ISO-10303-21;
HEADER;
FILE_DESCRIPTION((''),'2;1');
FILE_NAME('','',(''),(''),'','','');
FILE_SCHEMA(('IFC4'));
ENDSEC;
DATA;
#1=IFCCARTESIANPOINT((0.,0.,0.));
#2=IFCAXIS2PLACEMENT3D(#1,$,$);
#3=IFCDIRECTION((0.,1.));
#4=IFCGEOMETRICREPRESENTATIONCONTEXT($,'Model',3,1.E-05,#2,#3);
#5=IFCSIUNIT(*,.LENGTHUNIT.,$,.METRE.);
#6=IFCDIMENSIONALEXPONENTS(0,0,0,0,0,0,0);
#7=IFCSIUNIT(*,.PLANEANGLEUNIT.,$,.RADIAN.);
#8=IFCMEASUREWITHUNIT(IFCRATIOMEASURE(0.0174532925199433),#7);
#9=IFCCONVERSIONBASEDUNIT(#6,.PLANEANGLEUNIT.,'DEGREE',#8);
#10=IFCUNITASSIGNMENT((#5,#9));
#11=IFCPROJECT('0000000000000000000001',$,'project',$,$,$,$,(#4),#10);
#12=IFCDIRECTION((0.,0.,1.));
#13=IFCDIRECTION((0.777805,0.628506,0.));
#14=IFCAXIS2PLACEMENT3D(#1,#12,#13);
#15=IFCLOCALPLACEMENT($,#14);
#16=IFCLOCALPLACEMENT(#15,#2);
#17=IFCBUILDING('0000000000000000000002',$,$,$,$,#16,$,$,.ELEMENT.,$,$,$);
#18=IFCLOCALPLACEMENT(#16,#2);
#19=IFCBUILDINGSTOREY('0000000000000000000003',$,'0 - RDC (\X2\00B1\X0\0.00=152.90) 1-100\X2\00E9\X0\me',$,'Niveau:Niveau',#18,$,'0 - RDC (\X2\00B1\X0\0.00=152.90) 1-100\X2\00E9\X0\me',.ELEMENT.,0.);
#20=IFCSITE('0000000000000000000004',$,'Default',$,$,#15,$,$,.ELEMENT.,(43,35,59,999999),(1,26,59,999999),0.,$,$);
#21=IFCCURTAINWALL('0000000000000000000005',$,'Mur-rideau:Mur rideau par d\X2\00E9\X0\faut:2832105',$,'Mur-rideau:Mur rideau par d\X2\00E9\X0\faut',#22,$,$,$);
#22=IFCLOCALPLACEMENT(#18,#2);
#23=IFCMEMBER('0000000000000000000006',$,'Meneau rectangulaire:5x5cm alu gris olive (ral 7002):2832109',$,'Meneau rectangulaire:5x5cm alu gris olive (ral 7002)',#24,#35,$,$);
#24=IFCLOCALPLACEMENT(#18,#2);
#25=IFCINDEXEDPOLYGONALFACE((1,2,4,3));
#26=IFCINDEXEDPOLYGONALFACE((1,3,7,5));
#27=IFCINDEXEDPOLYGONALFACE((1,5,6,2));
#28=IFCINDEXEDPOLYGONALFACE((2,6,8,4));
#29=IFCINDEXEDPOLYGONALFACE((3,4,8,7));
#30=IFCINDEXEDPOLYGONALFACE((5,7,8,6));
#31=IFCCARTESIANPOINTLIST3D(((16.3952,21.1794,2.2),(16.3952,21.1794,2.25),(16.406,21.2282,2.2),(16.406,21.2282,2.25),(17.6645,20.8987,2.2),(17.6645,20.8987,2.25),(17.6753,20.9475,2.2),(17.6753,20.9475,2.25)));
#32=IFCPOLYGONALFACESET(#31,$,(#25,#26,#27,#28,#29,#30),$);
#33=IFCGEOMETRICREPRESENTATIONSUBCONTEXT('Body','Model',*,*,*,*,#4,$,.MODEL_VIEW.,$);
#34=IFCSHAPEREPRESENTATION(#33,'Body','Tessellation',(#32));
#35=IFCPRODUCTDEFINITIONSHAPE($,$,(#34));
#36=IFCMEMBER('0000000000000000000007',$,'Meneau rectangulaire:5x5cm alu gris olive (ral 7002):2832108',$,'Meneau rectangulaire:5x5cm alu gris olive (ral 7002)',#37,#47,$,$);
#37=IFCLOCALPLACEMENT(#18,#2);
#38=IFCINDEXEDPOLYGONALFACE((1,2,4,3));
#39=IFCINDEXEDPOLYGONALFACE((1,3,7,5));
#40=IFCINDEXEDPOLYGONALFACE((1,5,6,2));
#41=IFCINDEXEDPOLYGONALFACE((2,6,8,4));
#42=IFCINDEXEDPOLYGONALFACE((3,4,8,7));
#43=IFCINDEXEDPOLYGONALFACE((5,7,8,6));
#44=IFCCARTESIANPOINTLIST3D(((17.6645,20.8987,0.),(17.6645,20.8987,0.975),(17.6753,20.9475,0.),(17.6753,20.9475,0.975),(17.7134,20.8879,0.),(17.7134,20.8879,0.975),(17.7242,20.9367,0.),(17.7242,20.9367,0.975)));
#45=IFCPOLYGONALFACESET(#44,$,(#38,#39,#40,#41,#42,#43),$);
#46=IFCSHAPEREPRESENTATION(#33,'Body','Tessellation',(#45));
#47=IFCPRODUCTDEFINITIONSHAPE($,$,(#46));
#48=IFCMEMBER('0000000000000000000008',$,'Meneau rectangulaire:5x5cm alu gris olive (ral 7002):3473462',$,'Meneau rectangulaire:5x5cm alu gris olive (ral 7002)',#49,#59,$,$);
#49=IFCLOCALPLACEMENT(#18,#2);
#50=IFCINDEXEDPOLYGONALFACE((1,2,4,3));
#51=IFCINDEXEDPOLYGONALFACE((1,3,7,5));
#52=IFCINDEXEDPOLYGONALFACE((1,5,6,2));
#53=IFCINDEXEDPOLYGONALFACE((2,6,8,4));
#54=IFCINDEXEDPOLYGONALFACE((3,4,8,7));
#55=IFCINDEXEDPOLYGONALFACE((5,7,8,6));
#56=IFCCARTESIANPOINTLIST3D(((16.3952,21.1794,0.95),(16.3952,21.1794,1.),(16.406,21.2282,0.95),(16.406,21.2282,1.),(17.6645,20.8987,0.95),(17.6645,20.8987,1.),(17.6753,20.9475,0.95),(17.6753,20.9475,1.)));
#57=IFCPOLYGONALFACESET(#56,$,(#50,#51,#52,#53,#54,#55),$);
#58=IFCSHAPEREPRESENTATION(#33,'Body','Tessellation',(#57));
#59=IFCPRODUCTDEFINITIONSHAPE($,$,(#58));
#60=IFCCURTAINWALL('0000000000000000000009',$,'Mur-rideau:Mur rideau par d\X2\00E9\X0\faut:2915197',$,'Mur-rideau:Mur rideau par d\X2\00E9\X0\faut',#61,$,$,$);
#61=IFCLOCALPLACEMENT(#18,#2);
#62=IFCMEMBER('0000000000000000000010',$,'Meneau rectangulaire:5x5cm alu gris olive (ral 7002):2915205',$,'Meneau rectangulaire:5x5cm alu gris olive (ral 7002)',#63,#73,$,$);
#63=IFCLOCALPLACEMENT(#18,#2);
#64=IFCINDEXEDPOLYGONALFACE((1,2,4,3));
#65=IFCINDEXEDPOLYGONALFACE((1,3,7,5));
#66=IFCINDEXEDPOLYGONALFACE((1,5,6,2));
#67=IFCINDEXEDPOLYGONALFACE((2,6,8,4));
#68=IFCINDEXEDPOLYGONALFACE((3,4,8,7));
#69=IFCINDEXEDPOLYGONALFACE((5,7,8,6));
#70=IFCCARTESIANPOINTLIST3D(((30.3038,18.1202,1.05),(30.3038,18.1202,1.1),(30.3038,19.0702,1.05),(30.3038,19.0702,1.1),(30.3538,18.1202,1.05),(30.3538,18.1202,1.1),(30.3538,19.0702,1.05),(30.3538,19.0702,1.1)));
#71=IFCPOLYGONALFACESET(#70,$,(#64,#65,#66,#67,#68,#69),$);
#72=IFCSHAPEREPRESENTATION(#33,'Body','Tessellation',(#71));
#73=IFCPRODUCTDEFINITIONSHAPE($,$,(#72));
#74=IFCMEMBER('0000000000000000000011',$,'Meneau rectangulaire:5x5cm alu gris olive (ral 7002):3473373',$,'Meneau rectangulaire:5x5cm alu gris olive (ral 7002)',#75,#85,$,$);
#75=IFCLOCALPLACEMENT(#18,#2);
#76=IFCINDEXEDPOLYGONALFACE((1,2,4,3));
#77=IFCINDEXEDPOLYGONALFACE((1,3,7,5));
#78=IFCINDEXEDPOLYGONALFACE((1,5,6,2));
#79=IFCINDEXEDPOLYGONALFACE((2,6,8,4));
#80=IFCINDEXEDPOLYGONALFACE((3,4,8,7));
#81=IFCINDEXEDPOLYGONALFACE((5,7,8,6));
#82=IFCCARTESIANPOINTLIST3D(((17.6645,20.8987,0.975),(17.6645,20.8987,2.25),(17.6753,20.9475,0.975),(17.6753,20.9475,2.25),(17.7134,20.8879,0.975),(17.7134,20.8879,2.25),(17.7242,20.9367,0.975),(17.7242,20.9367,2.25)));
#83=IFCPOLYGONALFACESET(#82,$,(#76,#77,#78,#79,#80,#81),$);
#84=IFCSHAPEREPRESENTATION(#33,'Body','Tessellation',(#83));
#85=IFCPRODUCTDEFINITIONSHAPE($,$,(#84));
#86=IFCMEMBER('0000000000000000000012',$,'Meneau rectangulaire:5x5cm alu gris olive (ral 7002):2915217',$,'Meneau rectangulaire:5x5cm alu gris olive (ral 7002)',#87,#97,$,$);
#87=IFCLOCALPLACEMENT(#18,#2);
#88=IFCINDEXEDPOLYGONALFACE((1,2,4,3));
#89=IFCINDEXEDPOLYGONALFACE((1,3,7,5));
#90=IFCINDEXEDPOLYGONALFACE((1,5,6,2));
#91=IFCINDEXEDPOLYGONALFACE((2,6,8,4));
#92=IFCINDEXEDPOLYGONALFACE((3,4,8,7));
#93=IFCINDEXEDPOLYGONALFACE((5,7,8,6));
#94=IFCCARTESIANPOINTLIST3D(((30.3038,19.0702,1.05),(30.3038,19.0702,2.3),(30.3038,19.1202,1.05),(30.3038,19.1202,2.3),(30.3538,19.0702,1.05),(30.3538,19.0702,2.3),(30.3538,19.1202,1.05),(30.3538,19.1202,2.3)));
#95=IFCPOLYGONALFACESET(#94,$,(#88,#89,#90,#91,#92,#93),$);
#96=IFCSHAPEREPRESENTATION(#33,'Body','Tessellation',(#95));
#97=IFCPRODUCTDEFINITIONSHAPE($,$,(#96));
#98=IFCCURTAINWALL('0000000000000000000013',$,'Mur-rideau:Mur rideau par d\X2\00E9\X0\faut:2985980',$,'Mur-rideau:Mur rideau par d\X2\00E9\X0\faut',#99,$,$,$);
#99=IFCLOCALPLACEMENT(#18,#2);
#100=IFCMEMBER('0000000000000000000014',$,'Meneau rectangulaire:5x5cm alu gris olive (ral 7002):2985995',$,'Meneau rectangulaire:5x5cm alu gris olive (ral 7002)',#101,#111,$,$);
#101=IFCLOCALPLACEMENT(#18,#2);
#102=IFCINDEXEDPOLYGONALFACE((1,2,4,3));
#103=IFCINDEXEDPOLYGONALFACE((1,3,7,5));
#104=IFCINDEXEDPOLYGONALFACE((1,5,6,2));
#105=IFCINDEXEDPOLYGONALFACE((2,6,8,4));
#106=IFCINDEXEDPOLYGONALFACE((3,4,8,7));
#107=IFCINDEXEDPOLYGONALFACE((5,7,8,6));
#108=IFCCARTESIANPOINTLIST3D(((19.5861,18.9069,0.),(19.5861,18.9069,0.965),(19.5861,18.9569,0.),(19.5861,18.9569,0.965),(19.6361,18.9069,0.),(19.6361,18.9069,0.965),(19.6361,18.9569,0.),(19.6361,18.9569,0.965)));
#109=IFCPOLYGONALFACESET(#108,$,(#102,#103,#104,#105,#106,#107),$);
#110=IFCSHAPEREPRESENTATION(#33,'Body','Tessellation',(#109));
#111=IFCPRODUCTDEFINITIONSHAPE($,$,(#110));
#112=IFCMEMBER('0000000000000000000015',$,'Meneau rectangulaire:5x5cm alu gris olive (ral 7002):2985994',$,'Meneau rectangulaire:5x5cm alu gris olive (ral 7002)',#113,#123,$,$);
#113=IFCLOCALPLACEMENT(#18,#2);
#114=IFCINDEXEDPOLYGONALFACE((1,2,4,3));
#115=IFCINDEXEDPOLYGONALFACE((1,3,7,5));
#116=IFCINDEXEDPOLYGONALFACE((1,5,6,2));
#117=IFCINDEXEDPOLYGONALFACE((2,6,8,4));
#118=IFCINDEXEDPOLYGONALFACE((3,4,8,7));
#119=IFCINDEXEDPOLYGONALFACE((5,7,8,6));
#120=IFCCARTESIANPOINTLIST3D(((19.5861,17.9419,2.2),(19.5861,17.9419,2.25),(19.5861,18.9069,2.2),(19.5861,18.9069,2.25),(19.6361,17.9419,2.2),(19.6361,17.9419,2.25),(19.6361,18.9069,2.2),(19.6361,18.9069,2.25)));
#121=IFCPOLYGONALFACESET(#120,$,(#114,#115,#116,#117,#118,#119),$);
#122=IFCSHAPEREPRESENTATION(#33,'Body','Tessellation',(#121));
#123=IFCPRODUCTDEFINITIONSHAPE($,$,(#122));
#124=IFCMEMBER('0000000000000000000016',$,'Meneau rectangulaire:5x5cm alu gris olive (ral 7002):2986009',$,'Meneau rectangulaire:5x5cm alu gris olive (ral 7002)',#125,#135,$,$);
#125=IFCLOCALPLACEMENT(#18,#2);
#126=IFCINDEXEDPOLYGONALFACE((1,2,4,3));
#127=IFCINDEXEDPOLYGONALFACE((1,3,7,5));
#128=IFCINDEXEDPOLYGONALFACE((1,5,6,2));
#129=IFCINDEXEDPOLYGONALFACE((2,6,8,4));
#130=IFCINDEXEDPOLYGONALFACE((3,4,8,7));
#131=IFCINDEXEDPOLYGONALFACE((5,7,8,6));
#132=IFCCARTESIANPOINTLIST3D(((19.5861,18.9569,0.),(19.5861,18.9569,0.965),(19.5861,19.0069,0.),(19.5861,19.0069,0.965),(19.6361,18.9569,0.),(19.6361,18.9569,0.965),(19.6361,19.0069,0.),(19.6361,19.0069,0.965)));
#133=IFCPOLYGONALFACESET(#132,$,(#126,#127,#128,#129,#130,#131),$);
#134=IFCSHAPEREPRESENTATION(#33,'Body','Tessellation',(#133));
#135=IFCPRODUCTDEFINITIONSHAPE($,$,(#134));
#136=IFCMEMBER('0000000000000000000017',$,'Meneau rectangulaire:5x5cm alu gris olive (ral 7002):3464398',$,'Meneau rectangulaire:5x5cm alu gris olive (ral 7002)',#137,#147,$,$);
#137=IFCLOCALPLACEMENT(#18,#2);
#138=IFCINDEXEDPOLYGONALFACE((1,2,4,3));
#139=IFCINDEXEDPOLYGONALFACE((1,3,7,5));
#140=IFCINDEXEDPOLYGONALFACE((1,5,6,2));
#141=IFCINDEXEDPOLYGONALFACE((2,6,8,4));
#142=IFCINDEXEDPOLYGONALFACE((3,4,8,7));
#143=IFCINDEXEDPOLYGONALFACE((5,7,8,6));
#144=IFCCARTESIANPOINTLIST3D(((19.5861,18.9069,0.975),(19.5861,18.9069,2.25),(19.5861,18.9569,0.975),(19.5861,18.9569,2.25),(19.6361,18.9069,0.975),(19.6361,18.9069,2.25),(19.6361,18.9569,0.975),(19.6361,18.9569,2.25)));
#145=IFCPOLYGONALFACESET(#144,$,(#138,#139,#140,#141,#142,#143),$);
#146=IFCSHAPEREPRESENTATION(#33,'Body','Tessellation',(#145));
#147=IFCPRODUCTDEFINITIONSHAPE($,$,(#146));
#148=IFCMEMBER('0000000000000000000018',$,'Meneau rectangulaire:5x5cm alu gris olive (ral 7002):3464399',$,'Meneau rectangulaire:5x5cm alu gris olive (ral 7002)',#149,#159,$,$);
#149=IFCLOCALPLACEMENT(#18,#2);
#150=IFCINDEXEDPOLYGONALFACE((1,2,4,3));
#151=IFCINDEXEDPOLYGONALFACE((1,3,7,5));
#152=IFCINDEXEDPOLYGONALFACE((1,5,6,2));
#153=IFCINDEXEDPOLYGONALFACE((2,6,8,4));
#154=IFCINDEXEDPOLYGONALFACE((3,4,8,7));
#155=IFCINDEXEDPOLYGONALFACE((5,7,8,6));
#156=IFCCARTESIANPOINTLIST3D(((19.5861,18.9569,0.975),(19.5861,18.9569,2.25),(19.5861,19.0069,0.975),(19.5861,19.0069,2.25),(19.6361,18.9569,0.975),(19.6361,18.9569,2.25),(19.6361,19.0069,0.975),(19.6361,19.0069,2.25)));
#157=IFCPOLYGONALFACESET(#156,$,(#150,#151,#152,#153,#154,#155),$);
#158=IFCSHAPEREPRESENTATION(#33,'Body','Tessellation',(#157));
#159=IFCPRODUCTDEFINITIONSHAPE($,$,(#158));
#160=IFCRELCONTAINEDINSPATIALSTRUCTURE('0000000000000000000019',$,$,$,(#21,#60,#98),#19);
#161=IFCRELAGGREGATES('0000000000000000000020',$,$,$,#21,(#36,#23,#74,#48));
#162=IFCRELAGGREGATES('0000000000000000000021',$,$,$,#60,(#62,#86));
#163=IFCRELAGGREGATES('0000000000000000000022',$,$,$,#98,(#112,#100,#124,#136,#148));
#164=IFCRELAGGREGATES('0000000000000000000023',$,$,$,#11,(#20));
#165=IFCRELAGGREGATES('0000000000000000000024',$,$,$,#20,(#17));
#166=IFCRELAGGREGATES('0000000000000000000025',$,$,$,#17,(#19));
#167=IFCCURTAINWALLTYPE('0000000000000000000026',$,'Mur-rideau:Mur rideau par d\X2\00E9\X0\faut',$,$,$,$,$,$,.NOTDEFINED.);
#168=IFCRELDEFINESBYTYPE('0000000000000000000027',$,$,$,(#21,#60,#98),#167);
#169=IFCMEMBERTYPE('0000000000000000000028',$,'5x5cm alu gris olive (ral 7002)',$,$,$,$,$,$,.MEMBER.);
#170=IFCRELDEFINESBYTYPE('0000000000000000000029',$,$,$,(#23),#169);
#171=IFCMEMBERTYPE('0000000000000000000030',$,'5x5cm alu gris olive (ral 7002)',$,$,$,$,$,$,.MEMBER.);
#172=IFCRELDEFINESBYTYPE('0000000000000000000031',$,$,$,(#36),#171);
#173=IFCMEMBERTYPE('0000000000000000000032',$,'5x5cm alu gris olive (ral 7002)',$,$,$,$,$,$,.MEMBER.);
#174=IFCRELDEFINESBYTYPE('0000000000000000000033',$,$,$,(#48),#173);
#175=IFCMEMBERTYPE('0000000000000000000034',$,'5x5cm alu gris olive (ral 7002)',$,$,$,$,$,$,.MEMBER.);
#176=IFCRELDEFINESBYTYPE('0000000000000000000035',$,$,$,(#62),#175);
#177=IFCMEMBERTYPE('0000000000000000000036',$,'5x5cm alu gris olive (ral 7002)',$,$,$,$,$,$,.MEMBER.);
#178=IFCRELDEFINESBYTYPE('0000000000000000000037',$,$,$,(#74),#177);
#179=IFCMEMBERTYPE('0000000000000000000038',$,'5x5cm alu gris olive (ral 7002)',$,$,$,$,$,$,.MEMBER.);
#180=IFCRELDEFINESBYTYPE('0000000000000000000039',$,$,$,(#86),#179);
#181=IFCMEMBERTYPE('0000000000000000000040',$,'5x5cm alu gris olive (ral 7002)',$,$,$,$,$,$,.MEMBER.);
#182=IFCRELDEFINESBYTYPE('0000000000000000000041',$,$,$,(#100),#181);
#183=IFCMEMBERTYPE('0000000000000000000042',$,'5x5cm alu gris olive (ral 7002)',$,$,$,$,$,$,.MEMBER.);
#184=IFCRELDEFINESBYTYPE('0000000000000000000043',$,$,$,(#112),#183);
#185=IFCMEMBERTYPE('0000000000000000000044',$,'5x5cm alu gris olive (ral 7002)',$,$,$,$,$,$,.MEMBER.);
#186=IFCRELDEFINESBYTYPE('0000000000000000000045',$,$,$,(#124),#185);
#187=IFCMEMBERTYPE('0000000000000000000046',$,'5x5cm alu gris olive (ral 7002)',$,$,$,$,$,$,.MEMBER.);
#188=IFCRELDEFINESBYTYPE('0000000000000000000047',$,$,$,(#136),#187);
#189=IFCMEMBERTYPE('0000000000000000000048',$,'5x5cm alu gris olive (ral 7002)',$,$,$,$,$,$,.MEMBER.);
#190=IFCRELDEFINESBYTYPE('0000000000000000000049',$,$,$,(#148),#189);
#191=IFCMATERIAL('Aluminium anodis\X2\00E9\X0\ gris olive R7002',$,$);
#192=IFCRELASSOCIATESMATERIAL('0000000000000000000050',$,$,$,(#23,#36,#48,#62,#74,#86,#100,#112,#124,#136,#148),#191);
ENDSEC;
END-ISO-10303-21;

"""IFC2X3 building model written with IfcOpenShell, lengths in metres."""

from ifc_helpers import new_model, entity, si_unit, converted_unit, direction, frame, origin, origin_2d_with_axis, place, context, subcontext, project, spatial, rectangle, extrude, source, transform, mapped, material, type_object, type_shapes, element, aggregate, save


model = new_model("IFC2X3")

# Units and contexts
model_context = context("Model", 3, precision=1e-05, world=origin(), true_north=direction((0.0, 1.0)))
body_context = subcontext(model_context, "Body", "Model", "MODEL_VIEW")
ifc_project = project(units=[si_unit("LENGTHUNIT", "METRE"), converted_unit("PLANEANGLEUNIT", "DEGREE", entity("IfcRatioMeasure", 0.0174532925199433), si_unit("PLANEANGLEUNIT", "RADIAN"), dimensions=[0, 0, 0, 0, 0, 0, 0])], contexts=[model_context])

# Site, building, storey
site_placement = place(None, frame((0.0, 0.0, 0.0), z_axis=(0.0, 0.0, 1.0), x_axis=(0.777805, 0.628506, 0.0)))
site = spatial("IfcSite", under=ifc_project, at=site_placement, Name="Default", CompositionType="ELEMENT", RefLatitude=(43, 35, 59, 999999), RefLongitude=(1, 26, 59, 999999), RefElevation=0.0)
building_placement = place(site_placement, origin())
building = spatial("IfcBuilding", under=site, at=building_placement, CompositionType="ELEMENT")
storey_placement = place(building_placement, origin())
storey = spatial("IfcBuildingStorey", under=building, at=storey_placement, Name="0 - RDC (±0.00=152.90) 1-100éme", ObjectType="Niveau:Niveau", LongName="0 - RDC (±0.00=152.90) 1-100éme", CompositionType="ELEMENT", Elevation=0.0)

# Curtain wall, members
curtain_wall_type = type_object("IfcCurtainWallType", Name="Mur-rideau:Mur rideau par défaut", PredefinedType="NOTDEFINED")
curtain_wall_1_placement = place(storey_placement, origin())
curtain_wall_1 = element("IfcCurtainWall", 1, at=curtain_wall_1_placement, inside=storey, type_object=curtain_wall_type, Name="Mur-rideau:Mur rideau par défaut:2832105", ObjectType="Mur-rideau:Mur rideau par défaut")
ifc_material_1 = material(Name="Aluminium anodisé gris olive R7002")
member_type_1 = type_object("IfcMemberType", Name="5x5cm alu gris olive (ral 7002)", PredefinedType="MEMBER")
shared_shape_1 = source(origin(), body_context, "Body", "SweptSolid", [
    extrude(rectangle(XDim=0.05, YDim=0.05, at=origin_2d_with_axis()), frame((-0.025, 0.0, -1.3), z_axis=(0.0, 0.0, 1.0), x_axis=(0.0, -1.0, 0.0)), (0.0, 0.0, 1.0), 1.3),
])
type_shapes(member_type_1, [shared_shape_1])
member_1_placement = place(storey_placement, frame((17.6699, 20.9231, 2.25), z_axis=(0.976415, -0.2159, 0.0), x_axis=(0.0, 0.0, 1.0)))
member_1 = element("IfcMember", 2, at=member_1_placement, type_object=member_type_1, material=ifc_material_1, Name="Meneau rectangulaire:5x5cm alu gris olive (ral 7002):2832109", ObjectType="Meneau rectangulaire:5x5cm alu gris olive (ral 7002)", context=body_context, shape_type="MappedRepresentation", body=[
    mapped(shared_shape_1, transform((0.0, 0.0, 0.0), scale=1.0)),
])
member_type_2 = type_object("IfcMemberType", Name="5x5cm alu gris olive (ral 7002)", PredefinedType="MEMBER")
shared_shape_2 = source(origin(), body_context, "Body", "SweptSolid", [
    extrude(rectangle(XDim=0.05, YDim=0.05, at=origin_2d_with_axis()), frame((-0.025, 0.0, -0.975), z_axis=(0.0, 0.0, 1.0), x_axis=(0.0, -1.0, 0.0)), (0.0, 0.0, 1.0), 0.975),
])
type_shapes(member_type_2, [shared_shape_2])
member_2_placement = place(storey_placement, frame((17.7188, 20.9123, 0.0), z_axis=(0.0, 0.0, -1.0), x_axis=(0.976415, -0.2159, 0.0)))
member_2 = element("IfcMember", 3, at=member_2_placement, type_object=member_type_2, material=ifc_material_1, Name="Meneau rectangulaire:5x5cm alu gris olive (ral 7002):2832108", ObjectType="Meneau rectangulaire:5x5cm alu gris olive (ral 7002)", context=body_context, shape_type="MappedRepresentation", body=[
    mapped(shared_shape_2, transform((0.0, 0.0, 0.0), scale=1.0)),
])
member_type_3 = type_object("IfcMemberType", Name="5x5cm alu gris olive (ral 7002)", PredefinedType="MEMBER")
shared_shape_3 = source(origin(), body_context, "Body", "SweptSolid", [
    extrude(rectangle(XDim=0.05, YDim=0.05, at=origin_2d_with_axis()), frame((0.0, 0.0, -1.3), z_axis=(0.0, 0.0, 1.0), x_axis=(0.0, -1.0, 0.0)), (0.0, 0.0, 1.0), 1.3),
])
type_shapes(member_type_3, [shared_shape_3])
member_3_placement = place(storey_placement, frame((17.6699, 20.9231, 0.975), z_axis=(0.976415, -0.2159, 0.0), x_axis=(0.0, 0.0, 1.0)))
member_3 = element("IfcMember", 4, at=member_3_placement, type_object=member_type_3, material=ifc_material_1, Name="Meneau rectangulaire:5x5cm alu gris olive (ral 7002):3473462", ObjectType="Meneau rectangulaire:5x5cm alu gris olive (ral 7002)", context=body_context, shape_type="MappedRepresentation", body=[
    mapped(shared_shape_3, transform((0.0, 0.0, 0.0), scale=1.0)),
])

# Curtain wall, member
curtain_wall_2_placement = place(storey_placement, origin())
curtain_wall_2 = element("IfcCurtainWall", 5, at=curtain_wall_2_placement, inside=storey, type_object=curtain_wall_type, Name="Mur-rideau:Mur rideau par défaut:2915197", ObjectType="Mur-rideau:Mur rideau par défaut")
member_type_4 = type_object("IfcMemberType", Name="5x5cm alu gris olive (ral 7002)", PredefinedType="MEMBER")
shared_shape_4 = source(origin(), body_context, "Body", "SweptSolid", [
    extrude(rectangle(XDim=0.05, YDim=0.05, at=origin_2d_with_axis()), frame((-0.025, 0.0, -0.95), z_axis=(0.0, 0.0, 1.0), x_axis=(0.0, -1.0, 0.0)), (0.0, 0.0, 1.0), 0.95),
])
type_shapes(member_type_4, [shared_shape_4])
member_4_placement = place(storey_placement, frame((30.3288, 19.0702, 1.05), z_axis=(0.0, 1.0, 0.0), x_axis=(0.0, 0.0, -1.0)))
member_4 = element("IfcMember", 6, at=member_4_placement, type_object=member_type_4, material=ifc_material_1, Name="Meneau rectangulaire:5x5cm alu gris olive (ral 7002):2915205", ObjectType="Meneau rectangulaire:5x5cm alu gris olive (ral 7002)", context=body_context, shape_type="MappedRepresentation", body=[
    mapped(shared_shape_4, transform((0.0, 0.0, 0.0), scale=1.0)),
])

# Members
member_type_5 = type_object("IfcMemberType", Name="5x5cm alu gris olive (ral 7002)", PredefinedType="MEMBER")
shared_shape_5 = source(origin(), body_context, "Body", "SweptSolid", [
    extrude(rectangle(XDim=0.05, YDim=0.05, at=origin_2d_with_axis()), frame((-0.025, 0.0, -1.275), z_axis=(0.0, 0.0, 1.0), x_axis=(0.0, -1.0, 0.0)), (0.0, 0.0, 1.0), 1.275),
])
type_shapes(member_type_5, [shared_shape_5])
member_5_placement = place(storey_placement, frame((17.7188, 20.9123, 0.975), z_axis=(0.0, 0.0, -1.0), x_axis=(0.976415, -0.2159, 0.0)))
member_5 = element("IfcMember", 7, at=member_5_placement, type_object=member_type_5, material=ifc_material_1, Name="Meneau rectangulaire:5x5cm alu gris olive (ral 7002):3473373", ObjectType="Meneau rectangulaire:5x5cm alu gris olive (ral 7002)", context=body_context, shape_type="MappedRepresentation", body=[
    mapped(shared_shape_5, transform((0.0, 0.0, 0.0), scale=1.0)),
])
member_type_6 = type_object("IfcMemberType", Name="5x5cm alu gris olive (ral 7002)", PredefinedType="MEMBER")
shared_shape_6 = source(origin(), body_context, "Body", "SweptSolid", [
    extrude(rectangle(XDim=0.05, YDim=0.05, at=origin_2d_with_axis()), frame((0.0, 0.0, -1.25), z_axis=(0.0, 0.0, 1.0), x_axis=(0.0, -1.0, 0.0)), (0.0, 0.0, 1.0), 1.25),
])
type_shapes(member_type_6, [shared_shape_6])
member_6_placement = place(storey_placement, frame((30.3288, 19.0952, 1.05), z_axis=(0.0, 0.0, -1.0), x_axis=(0.0, -1.0, 0.0)))
member_6 = element("IfcMember", 8, at=member_6_placement, type_object=member_type_6, material=ifc_material_1, Name="Meneau rectangulaire:5x5cm alu gris olive (ral 7002):2915217", ObjectType="Meneau rectangulaire:5x5cm alu gris olive (ral 7002)", context=body_context, shape_type="MappedRepresentation", body=[
    mapped(shared_shape_6, transform((0.0, 0.0, 0.0), scale=1.0)),
])

# Curtain wall, members
curtain_wall_3_placement = place(storey_placement, origin())
curtain_wall_3 = element("IfcCurtainWall", 9, at=curtain_wall_3_placement, inside=storey, type_object=curtain_wall_type, Name="Mur-rideau:Mur rideau par défaut:2985980", ObjectType="Mur-rideau:Mur rideau par défaut")
member_type_7 = type_object("IfcMemberType", Name="5x5cm alu gris olive (ral 7002)", PredefinedType="MEMBER")
shared_shape_7 = source(origin(), body_context, "Body", "SweptSolid", [
    extrude(rectangle(XDim=0.05, YDim=0.05, at=origin_2d_with_axis()), frame((0.0, 0.0, -0.965), z_axis=(0.0, 0.0, 1.0), x_axis=(0.0, -1.0, 0.0)), (0.0, 0.0, 1.0), 0.965),
])
type_shapes(member_type_7, [shared_shape_7])
member_7_placement = place(storey_placement, frame((19.6111, 18.9319, 0.0), z_axis=(0.0, 0.0, -1.0), x_axis=(0.0, 1.0, 0.0)))
member_7 = element("IfcMember", 10, at=member_7_placement, type_object=member_type_7, material=ifc_material_1, Name="Meneau rectangulaire:5x5cm alu gris olive (ral 7002):2985995", ObjectType="Meneau rectangulaire:5x5cm alu gris olive (ral 7002)", context=body_context, shape_type="MappedRepresentation", body=[
    mapped(shared_shape_7, transform((0.0, 0.0, 0.0), scale=1.0)),
])
member_type_8 = type_object("IfcMemberType", Name="5x5cm alu gris olive (ral 7002)", PredefinedType="MEMBER")
shared_shape_8 = source(origin(), body_context, "Body", "SweptSolid", [
    extrude(rectangle(XDim=0.05, YDim=0.05, at=origin_2d_with_axis()), frame((-0.025, 0.0, -0.965), z_axis=(0.0, 0.0, 1.0), x_axis=(0.0, -1.0, 0.0)), (0.0, 0.0, 1.0), 0.965),
])
type_shapes(member_type_8, [shared_shape_8])
member_8_placement = place(storey_placement, frame((19.6111, 18.9069, 2.25), z_axis=(0.0, 1.0, 0.0), x_axis=(0.0, 0.0, 1.0)))
member_8 = element("IfcMember", 11, at=member_8_placement, type_object=member_type_8, material=ifc_material_1, Name="Meneau rectangulaire:5x5cm alu gris olive (ral 7002):2985994", ObjectType="Meneau rectangulaire:5x5cm alu gris olive (ral 7002)", context=body_context, shape_type="MappedRepresentation", body=[
    mapped(shared_shape_8, transform((0.0, 0.0, 0.0), scale=1.0)),
])
member_type_9 = type_object("IfcMemberType", Name="5x5cm alu gris olive (ral 7002)", PredefinedType="MEMBER")
shared_shape_9 = source(origin(), body_context, "Body", "SweptSolid", [
    extrude(rectangle(XDim=0.05, YDim=0.05, at=origin_2d_with_axis()), frame((-0.025, 0.0, -0.965), z_axis=(0.0, 0.0, 1.0), x_axis=(0.0, -1.0, 0.0)), (0.0, 0.0, 1.0), 0.965),
])
type_shapes(member_type_9, [shared_shape_9])
member_9_placement = place(storey_placement, frame((19.6111, 19.0069, 0.0), z_axis=(0.0, 0.0, -1.0), x_axis=(0.0, 1.0, 0.0)))
member_9 = element("IfcMember", 12, at=member_9_placement, type_object=member_type_9, material=ifc_material_1, Name="Meneau rectangulaire:5x5cm alu gris olive (ral 7002):2986009", ObjectType="Meneau rectangulaire:5x5cm alu gris olive (ral 7002)", context=body_context, shape_type="MappedRepresentation", body=[
    mapped(shared_shape_9, transform((0.0, 0.0, 0.0), scale=1.0)),
])
member_type_10 = type_object("IfcMemberType", Name="5x5cm alu gris olive (ral 7002)", PredefinedType="MEMBER")
shared_shape_10 = source(origin(), body_context, "Body", "SweptSolid", [
    extrude(rectangle(XDim=0.05, YDim=0.05, at=origin_2d_with_axis()), frame((0.0, 0.0, -1.275), z_axis=(0.0, 0.0, 1.0), x_axis=(0.0, -1.0, 0.0)), (0.0, 0.0, 1.0), 1.275),
])
type_shapes(member_type_10, [shared_shape_10])
member_10_placement = place(storey_placement, frame((19.6111, 18.9319, 0.975), z_axis=(0.0, 0.0, -1.0), x_axis=(0.0, 1.0, 0.0)))
member_10 = element("IfcMember", 13, at=member_10_placement, type_object=member_type_10, material=ifc_material_1, Name="Meneau rectangulaire:5x5cm alu gris olive (ral 7002):3464398", ObjectType="Meneau rectangulaire:5x5cm alu gris olive (ral 7002)", context=body_context, shape_type="MappedRepresentation", body=[
    mapped(shared_shape_10, transform((0.0, 0.0, 0.0), scale=1.0)),
])
member_type_11 = type_object("IfcMemberType", Name="5x5cm alu gris olive (ral 7002)", PredefinedType="MEMBER")
shared_shape_11 = source(origin(), body_context, "Body", "SweptSolid", [
    extrude(rectangle(XDim=0.05, YDim=0.05, at=origin_2d_with_axis()), frame((-0.025, 0.0, -1.275), z_axis=(0.0, 0.0, 1.0), x_axis=(0.0, -1.0, 0.0)), (0.0, 0.0, 1.0), 1.275),
])
type_shapes(member_type_11, [shared_shape_11])
member_11_placement = place(storey_placement, frame((19.6111, 19.0069, 0.975), z_axis=(0.0, 0.0, -1.0), x_axis=(0.0, 1.0, 0.0)))
member_11 = element("IfcMember", 14, at=member_11_placement, type_object=member_type_11, material=ifc_material_1, Name="Meneau rectangulaire:5x5cm alu gris olive (ral 7002):3464399", ObjectType="Meneau rectangulaire:5x5cm alu gris olive (ral 7002)", context=body_context, shape_type="MappedRepresentation", body=[
    mapped(shared_shape_11, transform((0.0, 0.0, 0.0), scale=1.0)),
])

aggregate(curtain_wall_1, [member_2, member_1, member_5, member_3])
aggregate(curtain_wall_2, [member_4, member_6])
aggregate(curtain_wall_3, [member_8, member_7, member_9, member_10, member_11])

save(model, "model.ifc")
